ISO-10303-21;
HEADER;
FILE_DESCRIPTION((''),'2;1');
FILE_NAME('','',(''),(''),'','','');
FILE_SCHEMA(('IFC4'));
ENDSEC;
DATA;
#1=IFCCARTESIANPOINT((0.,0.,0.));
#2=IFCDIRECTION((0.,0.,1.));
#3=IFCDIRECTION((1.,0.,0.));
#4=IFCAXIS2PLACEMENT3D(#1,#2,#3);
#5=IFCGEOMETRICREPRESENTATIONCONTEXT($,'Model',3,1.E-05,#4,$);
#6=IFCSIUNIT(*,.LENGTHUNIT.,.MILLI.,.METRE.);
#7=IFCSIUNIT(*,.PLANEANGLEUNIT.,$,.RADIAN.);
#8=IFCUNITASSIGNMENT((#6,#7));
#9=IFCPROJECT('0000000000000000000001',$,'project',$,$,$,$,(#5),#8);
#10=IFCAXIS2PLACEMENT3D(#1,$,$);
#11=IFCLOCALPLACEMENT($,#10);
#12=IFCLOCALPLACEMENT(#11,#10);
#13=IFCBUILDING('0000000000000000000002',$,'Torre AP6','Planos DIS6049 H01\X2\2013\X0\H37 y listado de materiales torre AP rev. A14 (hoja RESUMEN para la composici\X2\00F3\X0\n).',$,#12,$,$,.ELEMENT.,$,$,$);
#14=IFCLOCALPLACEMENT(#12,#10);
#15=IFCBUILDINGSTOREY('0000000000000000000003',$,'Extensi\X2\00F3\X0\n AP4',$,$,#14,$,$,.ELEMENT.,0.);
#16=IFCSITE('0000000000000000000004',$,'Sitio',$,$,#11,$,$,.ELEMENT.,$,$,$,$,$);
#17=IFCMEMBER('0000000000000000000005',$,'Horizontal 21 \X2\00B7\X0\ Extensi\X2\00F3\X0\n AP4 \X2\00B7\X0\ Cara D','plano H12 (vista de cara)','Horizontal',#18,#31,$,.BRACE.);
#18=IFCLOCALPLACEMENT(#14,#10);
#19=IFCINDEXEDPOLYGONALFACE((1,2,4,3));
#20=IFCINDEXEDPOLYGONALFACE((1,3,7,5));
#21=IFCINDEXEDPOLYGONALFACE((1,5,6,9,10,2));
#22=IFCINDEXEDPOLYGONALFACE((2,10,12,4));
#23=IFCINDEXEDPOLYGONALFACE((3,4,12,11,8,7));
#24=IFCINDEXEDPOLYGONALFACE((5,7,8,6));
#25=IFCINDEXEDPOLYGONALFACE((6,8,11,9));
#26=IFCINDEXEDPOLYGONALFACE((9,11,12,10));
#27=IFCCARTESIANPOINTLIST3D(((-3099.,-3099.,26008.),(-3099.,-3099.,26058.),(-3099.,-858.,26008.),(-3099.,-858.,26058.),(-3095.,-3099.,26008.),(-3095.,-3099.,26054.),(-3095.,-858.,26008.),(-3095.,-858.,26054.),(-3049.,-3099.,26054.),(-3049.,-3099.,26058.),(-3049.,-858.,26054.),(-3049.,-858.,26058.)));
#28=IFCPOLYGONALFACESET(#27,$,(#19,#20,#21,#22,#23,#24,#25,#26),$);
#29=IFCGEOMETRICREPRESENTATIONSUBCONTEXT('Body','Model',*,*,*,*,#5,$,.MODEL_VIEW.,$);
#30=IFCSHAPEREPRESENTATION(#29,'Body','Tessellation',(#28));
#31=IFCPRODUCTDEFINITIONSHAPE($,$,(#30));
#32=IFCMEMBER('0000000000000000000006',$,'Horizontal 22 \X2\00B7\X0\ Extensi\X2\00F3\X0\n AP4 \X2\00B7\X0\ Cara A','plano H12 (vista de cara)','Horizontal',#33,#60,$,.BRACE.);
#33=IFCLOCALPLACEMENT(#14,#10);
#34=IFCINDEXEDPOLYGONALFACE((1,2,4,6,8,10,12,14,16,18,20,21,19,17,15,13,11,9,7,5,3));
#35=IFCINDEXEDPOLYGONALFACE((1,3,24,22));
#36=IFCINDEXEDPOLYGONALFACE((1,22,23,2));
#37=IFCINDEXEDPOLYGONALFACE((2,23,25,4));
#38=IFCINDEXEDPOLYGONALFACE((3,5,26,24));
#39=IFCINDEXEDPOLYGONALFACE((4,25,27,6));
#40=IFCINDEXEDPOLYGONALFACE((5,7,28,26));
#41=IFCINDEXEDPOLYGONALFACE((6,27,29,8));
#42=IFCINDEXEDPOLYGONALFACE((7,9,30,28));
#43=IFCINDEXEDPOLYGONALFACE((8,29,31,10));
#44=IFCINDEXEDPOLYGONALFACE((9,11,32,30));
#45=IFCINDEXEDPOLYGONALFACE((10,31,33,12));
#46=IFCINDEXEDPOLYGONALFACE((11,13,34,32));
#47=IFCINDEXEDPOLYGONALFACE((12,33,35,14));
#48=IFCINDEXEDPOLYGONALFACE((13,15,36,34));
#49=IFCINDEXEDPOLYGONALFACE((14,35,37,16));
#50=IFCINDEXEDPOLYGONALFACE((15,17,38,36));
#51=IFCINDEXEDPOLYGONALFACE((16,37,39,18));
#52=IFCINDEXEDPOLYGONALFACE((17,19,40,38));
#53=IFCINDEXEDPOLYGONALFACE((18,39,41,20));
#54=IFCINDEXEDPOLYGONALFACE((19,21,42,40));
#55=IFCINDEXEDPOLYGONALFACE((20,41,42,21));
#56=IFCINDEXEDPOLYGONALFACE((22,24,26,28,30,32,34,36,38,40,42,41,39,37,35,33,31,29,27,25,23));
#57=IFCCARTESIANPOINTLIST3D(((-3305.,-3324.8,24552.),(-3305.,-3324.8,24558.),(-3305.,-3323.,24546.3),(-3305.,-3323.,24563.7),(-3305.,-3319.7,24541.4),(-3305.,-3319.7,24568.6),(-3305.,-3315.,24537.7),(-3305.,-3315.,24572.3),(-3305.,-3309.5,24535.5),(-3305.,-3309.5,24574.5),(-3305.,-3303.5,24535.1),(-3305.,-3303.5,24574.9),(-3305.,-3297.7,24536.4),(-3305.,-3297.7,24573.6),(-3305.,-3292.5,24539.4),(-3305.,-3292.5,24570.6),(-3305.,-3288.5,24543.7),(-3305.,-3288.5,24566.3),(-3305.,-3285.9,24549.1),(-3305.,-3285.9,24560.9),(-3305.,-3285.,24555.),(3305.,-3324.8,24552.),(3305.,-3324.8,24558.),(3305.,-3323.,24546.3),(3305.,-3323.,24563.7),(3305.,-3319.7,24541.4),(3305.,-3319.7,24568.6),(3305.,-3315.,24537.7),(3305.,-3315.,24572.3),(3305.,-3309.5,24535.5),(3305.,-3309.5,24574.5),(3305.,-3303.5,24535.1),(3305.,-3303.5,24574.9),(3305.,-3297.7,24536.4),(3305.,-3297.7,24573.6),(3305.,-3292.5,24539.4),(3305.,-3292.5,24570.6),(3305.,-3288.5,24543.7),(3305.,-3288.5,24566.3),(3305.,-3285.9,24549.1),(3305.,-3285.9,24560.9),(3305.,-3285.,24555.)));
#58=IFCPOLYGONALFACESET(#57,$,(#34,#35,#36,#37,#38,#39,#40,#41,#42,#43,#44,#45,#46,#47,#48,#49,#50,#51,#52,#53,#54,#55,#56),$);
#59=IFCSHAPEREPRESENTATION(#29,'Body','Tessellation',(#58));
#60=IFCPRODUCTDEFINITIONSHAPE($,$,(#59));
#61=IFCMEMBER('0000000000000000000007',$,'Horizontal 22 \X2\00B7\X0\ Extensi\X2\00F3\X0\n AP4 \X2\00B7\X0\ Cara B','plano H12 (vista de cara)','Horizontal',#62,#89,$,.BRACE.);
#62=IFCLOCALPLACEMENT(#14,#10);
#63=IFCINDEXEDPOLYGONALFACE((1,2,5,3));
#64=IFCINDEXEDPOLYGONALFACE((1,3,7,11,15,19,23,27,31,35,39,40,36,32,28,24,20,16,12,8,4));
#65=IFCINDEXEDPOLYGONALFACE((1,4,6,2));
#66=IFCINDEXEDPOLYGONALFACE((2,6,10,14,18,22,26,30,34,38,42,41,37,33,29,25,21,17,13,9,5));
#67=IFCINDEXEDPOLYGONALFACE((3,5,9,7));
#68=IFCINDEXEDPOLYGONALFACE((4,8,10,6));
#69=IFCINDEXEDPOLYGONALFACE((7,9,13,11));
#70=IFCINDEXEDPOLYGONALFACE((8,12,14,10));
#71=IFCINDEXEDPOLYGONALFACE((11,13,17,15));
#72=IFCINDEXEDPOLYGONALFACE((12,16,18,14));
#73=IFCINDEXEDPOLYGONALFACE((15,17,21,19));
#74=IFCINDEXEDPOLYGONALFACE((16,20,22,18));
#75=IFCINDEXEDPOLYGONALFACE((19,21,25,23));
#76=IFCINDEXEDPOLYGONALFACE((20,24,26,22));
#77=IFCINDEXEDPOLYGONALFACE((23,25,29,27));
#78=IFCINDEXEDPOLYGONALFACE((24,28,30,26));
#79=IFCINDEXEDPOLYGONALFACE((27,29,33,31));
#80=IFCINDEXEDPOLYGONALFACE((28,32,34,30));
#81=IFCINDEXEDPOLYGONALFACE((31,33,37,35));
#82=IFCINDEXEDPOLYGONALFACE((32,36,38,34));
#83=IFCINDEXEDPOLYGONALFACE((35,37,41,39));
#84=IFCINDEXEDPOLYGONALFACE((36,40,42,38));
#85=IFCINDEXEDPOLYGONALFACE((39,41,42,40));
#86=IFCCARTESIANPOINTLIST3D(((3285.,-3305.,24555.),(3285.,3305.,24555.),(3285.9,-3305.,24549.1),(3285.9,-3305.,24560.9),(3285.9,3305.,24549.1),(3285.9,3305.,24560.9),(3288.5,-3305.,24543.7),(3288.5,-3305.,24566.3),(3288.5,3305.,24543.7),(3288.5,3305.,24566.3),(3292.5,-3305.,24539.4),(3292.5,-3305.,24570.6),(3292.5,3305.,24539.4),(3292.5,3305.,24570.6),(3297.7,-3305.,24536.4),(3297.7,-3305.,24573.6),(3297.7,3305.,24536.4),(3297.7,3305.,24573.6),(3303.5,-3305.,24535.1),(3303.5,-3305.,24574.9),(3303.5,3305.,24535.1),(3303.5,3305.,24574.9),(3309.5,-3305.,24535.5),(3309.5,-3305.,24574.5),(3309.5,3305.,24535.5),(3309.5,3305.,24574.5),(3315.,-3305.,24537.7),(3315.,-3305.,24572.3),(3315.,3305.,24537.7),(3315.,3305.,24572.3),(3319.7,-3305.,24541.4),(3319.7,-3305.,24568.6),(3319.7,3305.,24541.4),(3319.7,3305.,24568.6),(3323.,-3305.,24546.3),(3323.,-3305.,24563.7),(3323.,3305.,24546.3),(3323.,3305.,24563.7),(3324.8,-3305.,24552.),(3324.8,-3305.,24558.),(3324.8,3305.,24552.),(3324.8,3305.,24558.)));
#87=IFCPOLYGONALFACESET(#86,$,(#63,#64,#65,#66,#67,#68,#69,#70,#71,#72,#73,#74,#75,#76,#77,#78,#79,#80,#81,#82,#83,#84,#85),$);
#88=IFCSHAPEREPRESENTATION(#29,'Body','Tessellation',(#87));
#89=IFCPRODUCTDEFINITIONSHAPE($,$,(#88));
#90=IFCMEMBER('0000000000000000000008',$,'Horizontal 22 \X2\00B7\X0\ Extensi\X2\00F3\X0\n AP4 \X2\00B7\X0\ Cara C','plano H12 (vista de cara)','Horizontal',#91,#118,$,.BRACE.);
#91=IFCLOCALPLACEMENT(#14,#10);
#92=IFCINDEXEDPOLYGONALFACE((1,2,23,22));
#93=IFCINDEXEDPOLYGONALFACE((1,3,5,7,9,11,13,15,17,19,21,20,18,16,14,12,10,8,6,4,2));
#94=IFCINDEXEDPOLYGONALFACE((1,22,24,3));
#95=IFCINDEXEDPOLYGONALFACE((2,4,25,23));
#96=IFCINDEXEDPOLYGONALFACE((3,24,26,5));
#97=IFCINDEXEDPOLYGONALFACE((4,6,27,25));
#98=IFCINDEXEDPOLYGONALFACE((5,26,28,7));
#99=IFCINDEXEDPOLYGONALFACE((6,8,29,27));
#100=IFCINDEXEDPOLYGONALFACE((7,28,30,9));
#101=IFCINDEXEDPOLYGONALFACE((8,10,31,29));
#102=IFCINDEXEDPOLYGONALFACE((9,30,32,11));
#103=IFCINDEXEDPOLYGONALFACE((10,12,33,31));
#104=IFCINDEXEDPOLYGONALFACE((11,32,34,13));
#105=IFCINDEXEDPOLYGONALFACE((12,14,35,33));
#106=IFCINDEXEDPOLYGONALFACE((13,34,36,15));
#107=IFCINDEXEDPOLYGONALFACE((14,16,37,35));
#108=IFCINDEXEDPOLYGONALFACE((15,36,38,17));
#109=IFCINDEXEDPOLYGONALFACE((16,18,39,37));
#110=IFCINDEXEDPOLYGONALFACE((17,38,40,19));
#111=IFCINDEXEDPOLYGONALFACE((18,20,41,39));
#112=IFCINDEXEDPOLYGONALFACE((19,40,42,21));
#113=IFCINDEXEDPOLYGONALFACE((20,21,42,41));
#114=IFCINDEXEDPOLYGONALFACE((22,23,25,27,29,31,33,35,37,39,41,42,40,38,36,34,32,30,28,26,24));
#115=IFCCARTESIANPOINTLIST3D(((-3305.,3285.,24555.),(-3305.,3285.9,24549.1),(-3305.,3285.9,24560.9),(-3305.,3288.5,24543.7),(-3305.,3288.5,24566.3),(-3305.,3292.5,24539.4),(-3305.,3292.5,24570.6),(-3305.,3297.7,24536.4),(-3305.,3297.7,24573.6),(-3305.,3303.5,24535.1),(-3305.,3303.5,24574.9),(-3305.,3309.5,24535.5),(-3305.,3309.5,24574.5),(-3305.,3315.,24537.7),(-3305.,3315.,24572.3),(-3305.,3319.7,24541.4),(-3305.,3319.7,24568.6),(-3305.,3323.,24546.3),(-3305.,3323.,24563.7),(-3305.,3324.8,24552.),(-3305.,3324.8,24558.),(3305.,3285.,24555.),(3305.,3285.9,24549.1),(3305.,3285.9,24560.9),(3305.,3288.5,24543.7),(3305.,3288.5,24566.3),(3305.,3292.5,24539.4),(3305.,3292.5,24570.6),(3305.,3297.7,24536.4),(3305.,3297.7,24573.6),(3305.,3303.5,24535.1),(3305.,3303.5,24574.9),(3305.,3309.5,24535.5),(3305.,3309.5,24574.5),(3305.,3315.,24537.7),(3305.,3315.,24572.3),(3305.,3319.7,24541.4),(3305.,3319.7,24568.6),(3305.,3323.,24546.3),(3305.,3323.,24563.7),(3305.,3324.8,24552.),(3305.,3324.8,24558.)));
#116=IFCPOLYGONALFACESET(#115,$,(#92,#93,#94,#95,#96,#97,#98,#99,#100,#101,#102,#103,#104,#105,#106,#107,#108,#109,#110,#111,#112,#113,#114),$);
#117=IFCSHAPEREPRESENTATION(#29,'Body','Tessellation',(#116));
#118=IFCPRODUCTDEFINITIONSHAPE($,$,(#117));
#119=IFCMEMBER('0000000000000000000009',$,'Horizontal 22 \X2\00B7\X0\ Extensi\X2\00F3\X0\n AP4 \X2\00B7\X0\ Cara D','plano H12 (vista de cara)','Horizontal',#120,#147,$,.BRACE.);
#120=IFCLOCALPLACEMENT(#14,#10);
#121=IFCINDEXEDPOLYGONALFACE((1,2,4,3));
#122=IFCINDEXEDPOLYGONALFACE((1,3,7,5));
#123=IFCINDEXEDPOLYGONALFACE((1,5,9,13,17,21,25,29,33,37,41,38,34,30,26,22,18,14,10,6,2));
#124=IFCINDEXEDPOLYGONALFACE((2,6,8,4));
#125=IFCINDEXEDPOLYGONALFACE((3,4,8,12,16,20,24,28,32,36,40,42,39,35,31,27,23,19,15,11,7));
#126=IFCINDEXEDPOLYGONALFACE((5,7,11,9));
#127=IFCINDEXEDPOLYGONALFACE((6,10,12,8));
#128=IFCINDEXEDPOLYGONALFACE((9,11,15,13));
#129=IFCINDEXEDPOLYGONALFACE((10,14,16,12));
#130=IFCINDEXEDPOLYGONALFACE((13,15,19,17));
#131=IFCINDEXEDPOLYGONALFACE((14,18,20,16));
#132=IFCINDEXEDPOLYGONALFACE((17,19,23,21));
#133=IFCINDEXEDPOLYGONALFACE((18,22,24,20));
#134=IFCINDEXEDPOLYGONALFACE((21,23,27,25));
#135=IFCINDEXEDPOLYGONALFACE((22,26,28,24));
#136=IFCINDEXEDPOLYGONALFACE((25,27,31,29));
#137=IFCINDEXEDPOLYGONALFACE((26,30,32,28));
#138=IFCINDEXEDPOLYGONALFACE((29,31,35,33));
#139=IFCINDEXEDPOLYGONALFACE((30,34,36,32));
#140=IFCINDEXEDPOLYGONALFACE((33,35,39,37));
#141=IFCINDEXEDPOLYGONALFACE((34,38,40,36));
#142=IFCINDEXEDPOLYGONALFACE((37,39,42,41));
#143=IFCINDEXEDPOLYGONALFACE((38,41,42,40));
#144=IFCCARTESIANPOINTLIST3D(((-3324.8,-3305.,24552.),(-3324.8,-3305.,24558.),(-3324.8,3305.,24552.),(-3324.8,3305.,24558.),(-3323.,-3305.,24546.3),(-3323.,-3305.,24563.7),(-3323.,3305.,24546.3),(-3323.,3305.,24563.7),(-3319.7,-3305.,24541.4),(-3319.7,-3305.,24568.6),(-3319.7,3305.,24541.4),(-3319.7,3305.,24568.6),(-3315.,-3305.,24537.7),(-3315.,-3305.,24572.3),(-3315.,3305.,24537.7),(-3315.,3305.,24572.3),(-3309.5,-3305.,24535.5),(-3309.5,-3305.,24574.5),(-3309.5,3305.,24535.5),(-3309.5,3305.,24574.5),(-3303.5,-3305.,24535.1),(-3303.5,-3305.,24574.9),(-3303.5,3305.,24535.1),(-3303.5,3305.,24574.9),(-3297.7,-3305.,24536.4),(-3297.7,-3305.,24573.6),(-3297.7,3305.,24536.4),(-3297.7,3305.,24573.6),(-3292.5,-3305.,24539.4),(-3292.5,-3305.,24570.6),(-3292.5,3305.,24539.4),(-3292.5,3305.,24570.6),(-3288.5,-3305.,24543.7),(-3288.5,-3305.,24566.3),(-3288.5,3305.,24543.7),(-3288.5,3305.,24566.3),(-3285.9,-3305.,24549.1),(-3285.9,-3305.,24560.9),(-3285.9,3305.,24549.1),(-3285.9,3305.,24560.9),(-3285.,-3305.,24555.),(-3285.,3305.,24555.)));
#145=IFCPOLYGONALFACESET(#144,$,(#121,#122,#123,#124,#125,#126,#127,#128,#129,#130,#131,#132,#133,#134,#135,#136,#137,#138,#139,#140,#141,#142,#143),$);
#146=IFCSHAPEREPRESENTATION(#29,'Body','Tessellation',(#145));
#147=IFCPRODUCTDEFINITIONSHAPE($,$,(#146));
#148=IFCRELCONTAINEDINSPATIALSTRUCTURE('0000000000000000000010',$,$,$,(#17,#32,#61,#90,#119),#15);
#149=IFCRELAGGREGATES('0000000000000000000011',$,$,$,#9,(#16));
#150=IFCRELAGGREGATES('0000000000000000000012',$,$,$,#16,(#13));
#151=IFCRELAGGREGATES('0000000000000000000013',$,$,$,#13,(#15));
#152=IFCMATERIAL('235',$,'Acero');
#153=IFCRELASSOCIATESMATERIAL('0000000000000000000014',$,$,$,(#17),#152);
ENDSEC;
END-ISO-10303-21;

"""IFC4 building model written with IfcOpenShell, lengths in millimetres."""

from ifc_helpers import new_model, si_unit, frame, frame_2d, origin, origin_with_axes, place, context, subcontext, project, spatial, circle, l_section, extrude, material, element, save


model = new_model("IFC4")

# Units and contexts
model_context = context("Model", 3, precision=1e-05, world=origin_with_axes())
body_context = subcontext(model_context, "Body", "Model", "MODEL_VIEW")
ifc_project = project(units=[si_unit("LENGTHUNIT", "METRE", prefix="MILLI"), si_unit("PLANEANGLEUNIT", "RADIAN")], contexts=[model_context])

# Site, building, storey
site_placement = place(None, origin())
site = spatial("IfcSite", under=ifc_project, at=site_placement, Name="Sitio", CompositionType="ELEMENT")
building_placement = place(site_placement, origin())
building = spatial("IfcBuilding", under=site, at=building_placement, Name="Torre AP6", Description="Planos DIS6049 H01–H37 y listado de materiales torre AP rev. A14 (hoja RESUMEN para la composición).", CompositionType="ELEMENT")
storey_placement = place(building_placement, origin())
storey = spatial("IfcBuildingStorey", under=building, at=storey_placement, Name="Extensión AP4", CompositionType="ELEMENT", Elevation=0.0)

# Members
ifc_material_1 = material(Name="235", Category="Acero")
for number, where, z_axis, x_axis, name in (
    (1, (-3099.0, -3099.0, 26058.0), (0.0, 1.0, 0.0), (1.0, 0.0, 0.0), "Horizontal 21 · Extensión AP4 · Cara D"),
):
    element("IfcMember", number, at=place(storey_placement, frame(where, z_axis=z_axis, x_axis=x_axis)), inside=storey, material=ifc_material_1, Name=name, Description="plano H12 (vista de cara)", ObjectType="Horizontal", PredefinedType="BRACE", context=body_context, shape_type="SweptSolid", body=[
        extrude(l_section(Depth=50.0, Width=50.0, Thickness=4.0, at=frame_2d((25.0, 25.0))), None, (0.0, 0.0, 1.0), 2241.0),
    ])
for number, where, z_axis, x_axis, name in (
    (2, (3305.0, -3305.0, 24555.0), (-1.0, 0.0, 0.0), (0.0, 1.0, 0.0), "Horizontal 22 · Extensión AP4 · Cara A"),
    (3, (3305.0, 3305.0, 24555.0), (0.0, -1.0, 0.0), (-1.0, 0.0, 0.0), "Horizontal 22 · Extensión AP4 · Cara B"),
    (4, (-3305.0, 3305.0, 24555.0), (1.0, 0.0, 0.0), (0.0, -1.0, 0.0), "Horizontal 22 · Extensión AP4 · Cara C"),
    (5, (-3305.0, -3305.0, 24555.0), (0.0, 1.0, 0.0), (1.0, 0.0, 0.0), "Horizontal 22 · Extensión AP4 · Cara D"),
):
    element("IfcMember", number, at=place(storey_placement, frame(where, z_axis=z_axis, x_axis=x_axis)), inside=storey, Name=name, Description="plano H12 (vista de cara)", ObjectType="Horizontal", PredefinedType="BRACE", context=body_context, shape_type="SweptSolid", body=[
        extrude(circle(Radius=20.0), None, (0.0, 0.0, 1.0), 6610.0),
    ])

save(model, "model.ifc")
